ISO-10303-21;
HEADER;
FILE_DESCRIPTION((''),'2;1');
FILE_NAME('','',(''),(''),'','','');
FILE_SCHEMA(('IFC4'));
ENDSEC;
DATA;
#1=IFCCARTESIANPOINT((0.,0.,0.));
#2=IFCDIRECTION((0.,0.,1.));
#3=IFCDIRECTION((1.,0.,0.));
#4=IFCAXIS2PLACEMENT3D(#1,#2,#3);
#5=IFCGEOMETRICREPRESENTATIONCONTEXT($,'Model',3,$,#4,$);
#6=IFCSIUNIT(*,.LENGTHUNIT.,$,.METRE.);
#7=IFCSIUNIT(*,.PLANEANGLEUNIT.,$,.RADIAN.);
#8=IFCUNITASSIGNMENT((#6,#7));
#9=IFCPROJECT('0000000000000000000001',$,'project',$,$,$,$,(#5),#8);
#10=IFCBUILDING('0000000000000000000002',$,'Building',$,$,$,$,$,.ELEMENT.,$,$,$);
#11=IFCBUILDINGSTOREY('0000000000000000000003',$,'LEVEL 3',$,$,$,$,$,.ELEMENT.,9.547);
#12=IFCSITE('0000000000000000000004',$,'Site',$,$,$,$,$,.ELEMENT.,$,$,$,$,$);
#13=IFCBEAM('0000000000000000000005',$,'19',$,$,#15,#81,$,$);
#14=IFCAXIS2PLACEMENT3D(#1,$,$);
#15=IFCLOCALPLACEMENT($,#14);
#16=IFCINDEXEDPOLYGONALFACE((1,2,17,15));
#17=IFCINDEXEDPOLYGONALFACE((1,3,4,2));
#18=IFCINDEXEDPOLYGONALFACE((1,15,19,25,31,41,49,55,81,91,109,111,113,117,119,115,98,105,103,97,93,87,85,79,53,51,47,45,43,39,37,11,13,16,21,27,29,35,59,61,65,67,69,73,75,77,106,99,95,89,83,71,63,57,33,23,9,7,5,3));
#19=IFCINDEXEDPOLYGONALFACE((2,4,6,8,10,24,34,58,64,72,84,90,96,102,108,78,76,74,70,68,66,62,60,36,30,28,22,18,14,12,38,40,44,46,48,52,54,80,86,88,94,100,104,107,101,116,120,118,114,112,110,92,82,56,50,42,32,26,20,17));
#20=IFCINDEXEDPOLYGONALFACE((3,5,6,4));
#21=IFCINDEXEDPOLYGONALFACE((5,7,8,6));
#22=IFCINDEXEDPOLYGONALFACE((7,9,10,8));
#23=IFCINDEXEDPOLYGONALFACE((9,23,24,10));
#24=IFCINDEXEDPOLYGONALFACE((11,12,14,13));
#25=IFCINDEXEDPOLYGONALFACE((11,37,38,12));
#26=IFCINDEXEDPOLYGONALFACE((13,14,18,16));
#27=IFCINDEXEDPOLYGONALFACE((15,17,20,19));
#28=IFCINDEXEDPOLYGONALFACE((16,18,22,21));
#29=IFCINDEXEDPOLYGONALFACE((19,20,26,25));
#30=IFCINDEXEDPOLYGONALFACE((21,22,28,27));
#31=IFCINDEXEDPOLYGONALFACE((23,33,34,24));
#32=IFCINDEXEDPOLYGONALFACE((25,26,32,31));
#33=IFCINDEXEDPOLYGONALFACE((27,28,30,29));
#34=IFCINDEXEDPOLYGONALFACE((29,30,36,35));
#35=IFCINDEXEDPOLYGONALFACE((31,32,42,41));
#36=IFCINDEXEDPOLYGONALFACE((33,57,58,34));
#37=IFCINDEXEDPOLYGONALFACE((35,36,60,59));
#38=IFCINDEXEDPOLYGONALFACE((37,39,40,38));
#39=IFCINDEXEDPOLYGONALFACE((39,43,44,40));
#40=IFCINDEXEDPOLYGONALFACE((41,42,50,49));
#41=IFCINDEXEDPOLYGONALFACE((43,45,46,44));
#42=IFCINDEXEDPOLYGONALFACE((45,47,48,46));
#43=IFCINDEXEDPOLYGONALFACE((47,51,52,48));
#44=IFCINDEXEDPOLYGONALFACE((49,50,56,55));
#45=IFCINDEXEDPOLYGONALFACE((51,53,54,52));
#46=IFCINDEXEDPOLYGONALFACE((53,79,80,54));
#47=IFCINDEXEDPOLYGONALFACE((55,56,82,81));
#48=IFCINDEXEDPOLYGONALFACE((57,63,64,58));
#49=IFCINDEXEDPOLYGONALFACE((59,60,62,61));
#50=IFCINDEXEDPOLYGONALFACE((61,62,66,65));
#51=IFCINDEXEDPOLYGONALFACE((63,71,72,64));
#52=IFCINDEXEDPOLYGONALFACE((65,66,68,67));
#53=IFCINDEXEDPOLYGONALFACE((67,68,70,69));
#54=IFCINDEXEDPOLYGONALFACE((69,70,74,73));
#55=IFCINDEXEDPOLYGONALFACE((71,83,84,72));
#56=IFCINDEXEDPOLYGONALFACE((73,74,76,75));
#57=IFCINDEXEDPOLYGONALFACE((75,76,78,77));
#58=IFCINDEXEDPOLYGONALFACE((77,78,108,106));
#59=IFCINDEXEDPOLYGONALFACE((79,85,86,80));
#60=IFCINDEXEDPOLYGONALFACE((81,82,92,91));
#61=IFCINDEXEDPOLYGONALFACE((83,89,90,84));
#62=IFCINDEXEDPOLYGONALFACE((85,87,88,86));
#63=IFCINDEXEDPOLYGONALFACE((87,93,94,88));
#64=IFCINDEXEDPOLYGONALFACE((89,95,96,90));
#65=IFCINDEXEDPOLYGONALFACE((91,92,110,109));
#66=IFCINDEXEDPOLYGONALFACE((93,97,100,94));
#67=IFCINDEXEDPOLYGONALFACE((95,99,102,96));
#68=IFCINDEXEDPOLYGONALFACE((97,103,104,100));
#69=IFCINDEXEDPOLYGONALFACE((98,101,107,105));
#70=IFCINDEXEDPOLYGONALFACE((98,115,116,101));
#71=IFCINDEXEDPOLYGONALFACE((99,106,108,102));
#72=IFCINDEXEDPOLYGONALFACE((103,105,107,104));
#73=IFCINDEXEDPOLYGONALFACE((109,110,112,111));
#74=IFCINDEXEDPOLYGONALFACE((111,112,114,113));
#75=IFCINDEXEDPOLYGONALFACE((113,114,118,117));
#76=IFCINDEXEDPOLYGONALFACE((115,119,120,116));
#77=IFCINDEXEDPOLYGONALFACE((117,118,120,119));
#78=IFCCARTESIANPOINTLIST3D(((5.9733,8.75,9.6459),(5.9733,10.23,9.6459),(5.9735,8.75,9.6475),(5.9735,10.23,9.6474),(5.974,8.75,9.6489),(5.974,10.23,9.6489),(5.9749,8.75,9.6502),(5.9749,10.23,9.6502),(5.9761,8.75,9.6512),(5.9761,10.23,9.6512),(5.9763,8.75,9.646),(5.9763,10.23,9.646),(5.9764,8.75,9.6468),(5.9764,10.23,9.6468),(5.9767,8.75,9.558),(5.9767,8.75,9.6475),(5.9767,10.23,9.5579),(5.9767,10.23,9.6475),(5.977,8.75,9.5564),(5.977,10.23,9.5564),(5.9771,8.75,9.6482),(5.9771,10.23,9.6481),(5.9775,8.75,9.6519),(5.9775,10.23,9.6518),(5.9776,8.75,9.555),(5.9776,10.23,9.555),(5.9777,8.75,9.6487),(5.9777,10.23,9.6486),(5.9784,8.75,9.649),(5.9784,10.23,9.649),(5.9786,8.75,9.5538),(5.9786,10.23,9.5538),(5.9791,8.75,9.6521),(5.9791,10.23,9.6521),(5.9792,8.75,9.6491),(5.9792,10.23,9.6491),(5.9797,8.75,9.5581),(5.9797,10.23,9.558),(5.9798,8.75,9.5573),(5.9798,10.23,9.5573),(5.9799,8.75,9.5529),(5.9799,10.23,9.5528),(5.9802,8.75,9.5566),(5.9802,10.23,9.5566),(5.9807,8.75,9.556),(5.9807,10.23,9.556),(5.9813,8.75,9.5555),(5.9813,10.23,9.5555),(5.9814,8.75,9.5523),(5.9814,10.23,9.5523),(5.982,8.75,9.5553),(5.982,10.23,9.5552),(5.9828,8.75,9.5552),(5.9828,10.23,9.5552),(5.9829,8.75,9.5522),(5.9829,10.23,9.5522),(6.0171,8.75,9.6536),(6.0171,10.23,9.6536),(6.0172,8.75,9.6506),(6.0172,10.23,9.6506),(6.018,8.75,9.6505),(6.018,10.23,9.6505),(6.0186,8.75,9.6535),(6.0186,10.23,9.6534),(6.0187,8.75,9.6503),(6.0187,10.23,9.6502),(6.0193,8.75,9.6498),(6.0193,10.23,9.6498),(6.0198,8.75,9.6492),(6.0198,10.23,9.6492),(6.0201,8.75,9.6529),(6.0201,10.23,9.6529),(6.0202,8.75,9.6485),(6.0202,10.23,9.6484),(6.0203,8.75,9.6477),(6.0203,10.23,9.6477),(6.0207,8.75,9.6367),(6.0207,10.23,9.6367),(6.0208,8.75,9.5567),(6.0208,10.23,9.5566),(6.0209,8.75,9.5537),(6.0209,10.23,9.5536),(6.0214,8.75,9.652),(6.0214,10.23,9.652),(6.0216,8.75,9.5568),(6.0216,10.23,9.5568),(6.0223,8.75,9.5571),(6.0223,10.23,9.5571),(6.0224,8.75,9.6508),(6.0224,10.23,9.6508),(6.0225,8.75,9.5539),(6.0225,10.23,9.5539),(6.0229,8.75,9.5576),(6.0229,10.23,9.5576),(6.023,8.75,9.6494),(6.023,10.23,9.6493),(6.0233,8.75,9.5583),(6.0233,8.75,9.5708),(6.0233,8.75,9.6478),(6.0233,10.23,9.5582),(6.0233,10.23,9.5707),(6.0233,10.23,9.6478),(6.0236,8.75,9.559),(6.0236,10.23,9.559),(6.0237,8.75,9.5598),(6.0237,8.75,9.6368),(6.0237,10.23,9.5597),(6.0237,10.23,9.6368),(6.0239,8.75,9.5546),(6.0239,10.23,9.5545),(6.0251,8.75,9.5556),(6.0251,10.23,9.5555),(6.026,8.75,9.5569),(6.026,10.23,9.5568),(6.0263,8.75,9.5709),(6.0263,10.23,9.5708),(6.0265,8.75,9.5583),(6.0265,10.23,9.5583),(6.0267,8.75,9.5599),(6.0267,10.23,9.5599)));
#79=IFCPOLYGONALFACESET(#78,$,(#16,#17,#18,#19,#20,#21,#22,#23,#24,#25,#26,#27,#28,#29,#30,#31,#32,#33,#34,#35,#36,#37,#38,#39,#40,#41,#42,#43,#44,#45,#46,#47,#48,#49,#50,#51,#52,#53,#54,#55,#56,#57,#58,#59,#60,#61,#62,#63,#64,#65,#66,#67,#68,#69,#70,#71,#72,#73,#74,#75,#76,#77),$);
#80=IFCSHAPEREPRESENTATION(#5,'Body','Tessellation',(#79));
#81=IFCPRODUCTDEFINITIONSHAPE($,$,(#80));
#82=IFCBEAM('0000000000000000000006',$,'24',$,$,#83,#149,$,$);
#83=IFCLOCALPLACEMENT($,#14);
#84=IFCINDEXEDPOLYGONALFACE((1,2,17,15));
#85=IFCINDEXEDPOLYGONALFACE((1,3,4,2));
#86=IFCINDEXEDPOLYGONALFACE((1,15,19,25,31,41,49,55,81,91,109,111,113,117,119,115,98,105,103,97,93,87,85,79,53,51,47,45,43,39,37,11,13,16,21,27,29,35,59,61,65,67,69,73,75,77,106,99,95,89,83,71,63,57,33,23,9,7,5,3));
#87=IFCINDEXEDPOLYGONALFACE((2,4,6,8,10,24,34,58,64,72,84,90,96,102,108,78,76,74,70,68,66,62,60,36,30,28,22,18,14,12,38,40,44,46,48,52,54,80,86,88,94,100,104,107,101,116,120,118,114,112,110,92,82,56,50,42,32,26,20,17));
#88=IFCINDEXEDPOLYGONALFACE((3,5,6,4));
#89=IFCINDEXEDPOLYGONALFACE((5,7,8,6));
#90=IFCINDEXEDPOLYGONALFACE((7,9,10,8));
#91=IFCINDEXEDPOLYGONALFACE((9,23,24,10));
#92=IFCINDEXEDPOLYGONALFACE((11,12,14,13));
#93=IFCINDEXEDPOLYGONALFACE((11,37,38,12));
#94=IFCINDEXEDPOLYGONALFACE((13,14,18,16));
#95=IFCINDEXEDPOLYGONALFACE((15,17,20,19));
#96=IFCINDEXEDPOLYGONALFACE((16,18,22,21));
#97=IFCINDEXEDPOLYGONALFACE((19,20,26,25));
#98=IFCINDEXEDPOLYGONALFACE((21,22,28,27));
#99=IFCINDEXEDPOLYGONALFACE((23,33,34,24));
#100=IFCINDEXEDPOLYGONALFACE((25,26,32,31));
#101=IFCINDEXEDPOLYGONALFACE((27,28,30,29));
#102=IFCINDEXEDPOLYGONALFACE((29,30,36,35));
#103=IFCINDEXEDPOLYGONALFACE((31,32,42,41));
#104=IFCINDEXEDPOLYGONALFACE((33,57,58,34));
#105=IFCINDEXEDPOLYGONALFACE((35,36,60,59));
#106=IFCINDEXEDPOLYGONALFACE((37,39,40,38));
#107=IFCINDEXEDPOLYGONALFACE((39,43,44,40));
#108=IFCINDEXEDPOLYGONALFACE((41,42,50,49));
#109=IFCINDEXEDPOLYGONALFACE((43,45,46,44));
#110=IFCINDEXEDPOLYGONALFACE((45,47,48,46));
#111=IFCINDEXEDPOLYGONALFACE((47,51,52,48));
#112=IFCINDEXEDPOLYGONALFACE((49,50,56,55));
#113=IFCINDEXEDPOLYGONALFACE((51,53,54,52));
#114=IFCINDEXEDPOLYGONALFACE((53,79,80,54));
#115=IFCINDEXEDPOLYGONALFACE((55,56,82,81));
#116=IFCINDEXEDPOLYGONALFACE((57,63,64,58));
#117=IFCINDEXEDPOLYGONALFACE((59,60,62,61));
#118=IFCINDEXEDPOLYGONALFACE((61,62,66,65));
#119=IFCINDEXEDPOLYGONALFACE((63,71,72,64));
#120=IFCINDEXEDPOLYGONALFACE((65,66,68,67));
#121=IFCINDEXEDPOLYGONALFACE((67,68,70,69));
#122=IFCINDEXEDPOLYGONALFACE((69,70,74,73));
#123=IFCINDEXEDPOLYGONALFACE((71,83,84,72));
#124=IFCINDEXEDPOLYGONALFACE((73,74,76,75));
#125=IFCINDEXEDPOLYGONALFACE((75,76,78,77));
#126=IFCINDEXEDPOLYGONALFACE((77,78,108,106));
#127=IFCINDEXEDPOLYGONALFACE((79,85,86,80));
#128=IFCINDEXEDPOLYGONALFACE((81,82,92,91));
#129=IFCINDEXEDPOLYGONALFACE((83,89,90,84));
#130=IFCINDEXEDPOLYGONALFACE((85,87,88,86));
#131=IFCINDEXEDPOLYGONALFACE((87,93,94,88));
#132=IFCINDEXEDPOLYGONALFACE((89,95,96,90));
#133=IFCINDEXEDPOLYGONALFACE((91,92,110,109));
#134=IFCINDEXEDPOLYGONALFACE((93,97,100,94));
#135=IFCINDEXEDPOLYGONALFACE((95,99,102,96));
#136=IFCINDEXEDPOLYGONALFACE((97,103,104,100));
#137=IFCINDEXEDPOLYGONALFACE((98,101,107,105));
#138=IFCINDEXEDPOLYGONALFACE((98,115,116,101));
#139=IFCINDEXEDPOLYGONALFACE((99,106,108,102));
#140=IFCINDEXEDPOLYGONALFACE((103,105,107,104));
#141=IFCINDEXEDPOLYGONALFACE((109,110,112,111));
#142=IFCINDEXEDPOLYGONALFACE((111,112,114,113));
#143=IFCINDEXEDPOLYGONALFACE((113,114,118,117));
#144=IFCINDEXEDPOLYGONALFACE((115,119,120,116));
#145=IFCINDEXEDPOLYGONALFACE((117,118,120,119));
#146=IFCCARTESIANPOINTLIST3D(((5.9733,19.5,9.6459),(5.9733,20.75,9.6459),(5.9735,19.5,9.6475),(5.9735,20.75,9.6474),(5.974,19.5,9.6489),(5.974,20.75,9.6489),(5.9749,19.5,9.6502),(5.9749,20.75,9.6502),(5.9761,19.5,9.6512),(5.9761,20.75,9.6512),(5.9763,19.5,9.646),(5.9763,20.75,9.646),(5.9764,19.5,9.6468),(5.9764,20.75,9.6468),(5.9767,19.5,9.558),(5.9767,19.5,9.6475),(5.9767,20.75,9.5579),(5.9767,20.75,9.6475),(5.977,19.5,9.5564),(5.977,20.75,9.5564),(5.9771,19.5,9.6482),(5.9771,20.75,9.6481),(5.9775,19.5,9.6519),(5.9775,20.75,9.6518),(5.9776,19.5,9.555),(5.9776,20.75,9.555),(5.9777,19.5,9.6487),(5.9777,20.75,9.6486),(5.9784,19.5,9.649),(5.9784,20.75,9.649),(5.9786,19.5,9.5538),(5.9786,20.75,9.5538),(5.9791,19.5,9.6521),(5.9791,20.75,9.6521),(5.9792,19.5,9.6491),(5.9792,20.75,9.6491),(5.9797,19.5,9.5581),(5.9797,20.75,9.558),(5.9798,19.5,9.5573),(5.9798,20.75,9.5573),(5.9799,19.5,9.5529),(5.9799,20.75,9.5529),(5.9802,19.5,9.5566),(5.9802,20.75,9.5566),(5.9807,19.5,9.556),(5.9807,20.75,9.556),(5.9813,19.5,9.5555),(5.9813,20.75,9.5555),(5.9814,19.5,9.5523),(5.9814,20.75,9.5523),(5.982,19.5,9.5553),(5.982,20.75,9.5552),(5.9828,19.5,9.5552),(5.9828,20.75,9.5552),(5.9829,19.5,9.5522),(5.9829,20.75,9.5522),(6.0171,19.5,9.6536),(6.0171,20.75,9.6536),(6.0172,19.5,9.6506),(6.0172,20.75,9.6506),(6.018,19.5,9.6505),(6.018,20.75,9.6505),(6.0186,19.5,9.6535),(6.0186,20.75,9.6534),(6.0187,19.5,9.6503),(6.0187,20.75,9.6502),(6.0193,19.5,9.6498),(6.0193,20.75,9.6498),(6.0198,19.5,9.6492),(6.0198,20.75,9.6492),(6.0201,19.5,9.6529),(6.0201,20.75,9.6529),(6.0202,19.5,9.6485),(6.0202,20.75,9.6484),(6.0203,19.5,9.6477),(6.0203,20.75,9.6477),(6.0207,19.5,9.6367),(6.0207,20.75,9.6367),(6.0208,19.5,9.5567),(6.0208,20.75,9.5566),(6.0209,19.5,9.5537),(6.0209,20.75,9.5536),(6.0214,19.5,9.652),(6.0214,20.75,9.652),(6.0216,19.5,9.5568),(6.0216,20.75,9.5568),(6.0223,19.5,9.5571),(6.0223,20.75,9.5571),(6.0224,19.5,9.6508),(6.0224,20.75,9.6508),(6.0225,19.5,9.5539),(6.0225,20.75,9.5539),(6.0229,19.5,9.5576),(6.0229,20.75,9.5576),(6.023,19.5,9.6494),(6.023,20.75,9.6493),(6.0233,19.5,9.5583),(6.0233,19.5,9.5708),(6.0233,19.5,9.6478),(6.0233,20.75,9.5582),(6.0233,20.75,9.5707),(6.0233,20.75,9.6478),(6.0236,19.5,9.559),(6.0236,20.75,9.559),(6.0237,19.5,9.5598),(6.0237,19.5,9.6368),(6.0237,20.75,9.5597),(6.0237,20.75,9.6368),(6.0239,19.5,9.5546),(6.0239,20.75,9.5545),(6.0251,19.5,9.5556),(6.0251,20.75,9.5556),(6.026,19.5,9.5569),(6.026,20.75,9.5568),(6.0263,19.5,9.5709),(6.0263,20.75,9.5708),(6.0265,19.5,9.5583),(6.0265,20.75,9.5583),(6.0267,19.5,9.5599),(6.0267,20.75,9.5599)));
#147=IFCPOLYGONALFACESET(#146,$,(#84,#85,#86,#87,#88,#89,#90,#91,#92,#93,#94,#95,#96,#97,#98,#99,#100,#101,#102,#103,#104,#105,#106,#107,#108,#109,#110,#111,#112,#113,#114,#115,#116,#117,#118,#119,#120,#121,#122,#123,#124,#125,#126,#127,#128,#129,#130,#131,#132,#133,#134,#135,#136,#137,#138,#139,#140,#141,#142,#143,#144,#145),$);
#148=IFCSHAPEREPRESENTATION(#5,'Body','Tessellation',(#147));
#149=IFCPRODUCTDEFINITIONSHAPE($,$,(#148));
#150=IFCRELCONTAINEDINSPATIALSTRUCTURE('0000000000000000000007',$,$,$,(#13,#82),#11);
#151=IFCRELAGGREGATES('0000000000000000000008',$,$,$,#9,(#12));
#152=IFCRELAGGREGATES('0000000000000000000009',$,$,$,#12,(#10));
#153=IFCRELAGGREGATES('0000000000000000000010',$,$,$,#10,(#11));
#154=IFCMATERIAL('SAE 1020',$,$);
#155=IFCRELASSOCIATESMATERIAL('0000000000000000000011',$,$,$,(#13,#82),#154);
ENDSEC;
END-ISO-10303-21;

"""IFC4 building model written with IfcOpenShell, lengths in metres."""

from ifc_helpers import new_model, si_unit, frame, origin_with_axes, origin_2d_with_axis, place, context, project, spatial, c_section, extrude, material, material_profile, profile_set, profile_usage, element, save


model = new_model("IFC4")

# Units and contexts
model_context = context("Model", 3, world=origin_with_axes())
ifc_project = project(units=[si_unit("LENGTHUNIT", "METRE"), si_unit("PLANEANGLEUNIT", "RADIAN")], contexts=[model_context])

# Site, building, storey
site = spatial("IfcSite", under=ifc_project, Name="Site", CompositionType="ELEMENT")
building = spatial("IfcBuilding", under=site, Name="Building", CompositionType="ELEMENT")
storey = spatial("IfcBuildingStorey", under=building, Name="LEVEL 3", CompositionType="ELEMENT", Elevation=9.547)

# Beams
ifc_material = material(Name="SAE 1020")
ifc_material_profile_1 = material_profile(ifc_material, c_section(Depth=0.1, Width=0.05, WallThickness=0.003, Girth=0.017, InternalFilletRadius=0.003, at=origin_2d_with_axis()))
ifc_profile_set_1 = profile_set([ifc_material_profile_1])
ifc_profile_usage_1 = profile_usage(ifc_profile_set_1, cardinal=10)
beam_1_placement = place(None, frame((6.0, 8.75, 9.6029), z_axis=(0.0, 1.0, -0.00003), x_axis=(0.999256, 0.000001, 0.038562)))
element("IfcBeam", 1, at=beam_1_placement, inside=storey, material=ifc_profile_usage_1, Name="19", context=model_context, shape_type="SweptSolid", body=[
    extrude(c_section(Depth=0.1, Width=0.05, WallThickness=0.003, Girth=0.017, InternalFilletRadius=0.003, at=origin_2d_with_axis()), origin_with_axes(), (0.0, 0.0, 1.0), 1.48),
])
ifc_material_profile_2 = material_profile(ifc_material, c_section(Depth=0.1, Width=0.05, WallThickness=0.003, Girth=0.017, InternalFilletRadius=0.003, at=origin_2d_with_axis()))
ifc_profile_set_2 = profile_set([ifc_material_profile_2])
ifc_profile_usage_2 = profile_usage(ifc_profile_set_2, cardinal=10)
beam_2_placement = place(None, frame((6.0, 19.5, 9.6029), z_axis=(0.0, 1.0, -0.00003), x_axis=(0.999256, 0.000001, 0.038562)))
element("IfcBeam", 2, at=beam_2_placement, inside=storey, material=ifc_profile_usage_2, Name="24", context=model_context, shape_type="SweptSolid", body=[
    extrude(c_section(Depth=0.1, Width=0.05, WallThickness=0.003, Girth=0.017, InternalFilletRadius=0.003, at=origin_2d_with_axis()), origin_with_axes(), (0.0, 0.0, 1.0), 1.25),
])

save(model, "model.ifc")
